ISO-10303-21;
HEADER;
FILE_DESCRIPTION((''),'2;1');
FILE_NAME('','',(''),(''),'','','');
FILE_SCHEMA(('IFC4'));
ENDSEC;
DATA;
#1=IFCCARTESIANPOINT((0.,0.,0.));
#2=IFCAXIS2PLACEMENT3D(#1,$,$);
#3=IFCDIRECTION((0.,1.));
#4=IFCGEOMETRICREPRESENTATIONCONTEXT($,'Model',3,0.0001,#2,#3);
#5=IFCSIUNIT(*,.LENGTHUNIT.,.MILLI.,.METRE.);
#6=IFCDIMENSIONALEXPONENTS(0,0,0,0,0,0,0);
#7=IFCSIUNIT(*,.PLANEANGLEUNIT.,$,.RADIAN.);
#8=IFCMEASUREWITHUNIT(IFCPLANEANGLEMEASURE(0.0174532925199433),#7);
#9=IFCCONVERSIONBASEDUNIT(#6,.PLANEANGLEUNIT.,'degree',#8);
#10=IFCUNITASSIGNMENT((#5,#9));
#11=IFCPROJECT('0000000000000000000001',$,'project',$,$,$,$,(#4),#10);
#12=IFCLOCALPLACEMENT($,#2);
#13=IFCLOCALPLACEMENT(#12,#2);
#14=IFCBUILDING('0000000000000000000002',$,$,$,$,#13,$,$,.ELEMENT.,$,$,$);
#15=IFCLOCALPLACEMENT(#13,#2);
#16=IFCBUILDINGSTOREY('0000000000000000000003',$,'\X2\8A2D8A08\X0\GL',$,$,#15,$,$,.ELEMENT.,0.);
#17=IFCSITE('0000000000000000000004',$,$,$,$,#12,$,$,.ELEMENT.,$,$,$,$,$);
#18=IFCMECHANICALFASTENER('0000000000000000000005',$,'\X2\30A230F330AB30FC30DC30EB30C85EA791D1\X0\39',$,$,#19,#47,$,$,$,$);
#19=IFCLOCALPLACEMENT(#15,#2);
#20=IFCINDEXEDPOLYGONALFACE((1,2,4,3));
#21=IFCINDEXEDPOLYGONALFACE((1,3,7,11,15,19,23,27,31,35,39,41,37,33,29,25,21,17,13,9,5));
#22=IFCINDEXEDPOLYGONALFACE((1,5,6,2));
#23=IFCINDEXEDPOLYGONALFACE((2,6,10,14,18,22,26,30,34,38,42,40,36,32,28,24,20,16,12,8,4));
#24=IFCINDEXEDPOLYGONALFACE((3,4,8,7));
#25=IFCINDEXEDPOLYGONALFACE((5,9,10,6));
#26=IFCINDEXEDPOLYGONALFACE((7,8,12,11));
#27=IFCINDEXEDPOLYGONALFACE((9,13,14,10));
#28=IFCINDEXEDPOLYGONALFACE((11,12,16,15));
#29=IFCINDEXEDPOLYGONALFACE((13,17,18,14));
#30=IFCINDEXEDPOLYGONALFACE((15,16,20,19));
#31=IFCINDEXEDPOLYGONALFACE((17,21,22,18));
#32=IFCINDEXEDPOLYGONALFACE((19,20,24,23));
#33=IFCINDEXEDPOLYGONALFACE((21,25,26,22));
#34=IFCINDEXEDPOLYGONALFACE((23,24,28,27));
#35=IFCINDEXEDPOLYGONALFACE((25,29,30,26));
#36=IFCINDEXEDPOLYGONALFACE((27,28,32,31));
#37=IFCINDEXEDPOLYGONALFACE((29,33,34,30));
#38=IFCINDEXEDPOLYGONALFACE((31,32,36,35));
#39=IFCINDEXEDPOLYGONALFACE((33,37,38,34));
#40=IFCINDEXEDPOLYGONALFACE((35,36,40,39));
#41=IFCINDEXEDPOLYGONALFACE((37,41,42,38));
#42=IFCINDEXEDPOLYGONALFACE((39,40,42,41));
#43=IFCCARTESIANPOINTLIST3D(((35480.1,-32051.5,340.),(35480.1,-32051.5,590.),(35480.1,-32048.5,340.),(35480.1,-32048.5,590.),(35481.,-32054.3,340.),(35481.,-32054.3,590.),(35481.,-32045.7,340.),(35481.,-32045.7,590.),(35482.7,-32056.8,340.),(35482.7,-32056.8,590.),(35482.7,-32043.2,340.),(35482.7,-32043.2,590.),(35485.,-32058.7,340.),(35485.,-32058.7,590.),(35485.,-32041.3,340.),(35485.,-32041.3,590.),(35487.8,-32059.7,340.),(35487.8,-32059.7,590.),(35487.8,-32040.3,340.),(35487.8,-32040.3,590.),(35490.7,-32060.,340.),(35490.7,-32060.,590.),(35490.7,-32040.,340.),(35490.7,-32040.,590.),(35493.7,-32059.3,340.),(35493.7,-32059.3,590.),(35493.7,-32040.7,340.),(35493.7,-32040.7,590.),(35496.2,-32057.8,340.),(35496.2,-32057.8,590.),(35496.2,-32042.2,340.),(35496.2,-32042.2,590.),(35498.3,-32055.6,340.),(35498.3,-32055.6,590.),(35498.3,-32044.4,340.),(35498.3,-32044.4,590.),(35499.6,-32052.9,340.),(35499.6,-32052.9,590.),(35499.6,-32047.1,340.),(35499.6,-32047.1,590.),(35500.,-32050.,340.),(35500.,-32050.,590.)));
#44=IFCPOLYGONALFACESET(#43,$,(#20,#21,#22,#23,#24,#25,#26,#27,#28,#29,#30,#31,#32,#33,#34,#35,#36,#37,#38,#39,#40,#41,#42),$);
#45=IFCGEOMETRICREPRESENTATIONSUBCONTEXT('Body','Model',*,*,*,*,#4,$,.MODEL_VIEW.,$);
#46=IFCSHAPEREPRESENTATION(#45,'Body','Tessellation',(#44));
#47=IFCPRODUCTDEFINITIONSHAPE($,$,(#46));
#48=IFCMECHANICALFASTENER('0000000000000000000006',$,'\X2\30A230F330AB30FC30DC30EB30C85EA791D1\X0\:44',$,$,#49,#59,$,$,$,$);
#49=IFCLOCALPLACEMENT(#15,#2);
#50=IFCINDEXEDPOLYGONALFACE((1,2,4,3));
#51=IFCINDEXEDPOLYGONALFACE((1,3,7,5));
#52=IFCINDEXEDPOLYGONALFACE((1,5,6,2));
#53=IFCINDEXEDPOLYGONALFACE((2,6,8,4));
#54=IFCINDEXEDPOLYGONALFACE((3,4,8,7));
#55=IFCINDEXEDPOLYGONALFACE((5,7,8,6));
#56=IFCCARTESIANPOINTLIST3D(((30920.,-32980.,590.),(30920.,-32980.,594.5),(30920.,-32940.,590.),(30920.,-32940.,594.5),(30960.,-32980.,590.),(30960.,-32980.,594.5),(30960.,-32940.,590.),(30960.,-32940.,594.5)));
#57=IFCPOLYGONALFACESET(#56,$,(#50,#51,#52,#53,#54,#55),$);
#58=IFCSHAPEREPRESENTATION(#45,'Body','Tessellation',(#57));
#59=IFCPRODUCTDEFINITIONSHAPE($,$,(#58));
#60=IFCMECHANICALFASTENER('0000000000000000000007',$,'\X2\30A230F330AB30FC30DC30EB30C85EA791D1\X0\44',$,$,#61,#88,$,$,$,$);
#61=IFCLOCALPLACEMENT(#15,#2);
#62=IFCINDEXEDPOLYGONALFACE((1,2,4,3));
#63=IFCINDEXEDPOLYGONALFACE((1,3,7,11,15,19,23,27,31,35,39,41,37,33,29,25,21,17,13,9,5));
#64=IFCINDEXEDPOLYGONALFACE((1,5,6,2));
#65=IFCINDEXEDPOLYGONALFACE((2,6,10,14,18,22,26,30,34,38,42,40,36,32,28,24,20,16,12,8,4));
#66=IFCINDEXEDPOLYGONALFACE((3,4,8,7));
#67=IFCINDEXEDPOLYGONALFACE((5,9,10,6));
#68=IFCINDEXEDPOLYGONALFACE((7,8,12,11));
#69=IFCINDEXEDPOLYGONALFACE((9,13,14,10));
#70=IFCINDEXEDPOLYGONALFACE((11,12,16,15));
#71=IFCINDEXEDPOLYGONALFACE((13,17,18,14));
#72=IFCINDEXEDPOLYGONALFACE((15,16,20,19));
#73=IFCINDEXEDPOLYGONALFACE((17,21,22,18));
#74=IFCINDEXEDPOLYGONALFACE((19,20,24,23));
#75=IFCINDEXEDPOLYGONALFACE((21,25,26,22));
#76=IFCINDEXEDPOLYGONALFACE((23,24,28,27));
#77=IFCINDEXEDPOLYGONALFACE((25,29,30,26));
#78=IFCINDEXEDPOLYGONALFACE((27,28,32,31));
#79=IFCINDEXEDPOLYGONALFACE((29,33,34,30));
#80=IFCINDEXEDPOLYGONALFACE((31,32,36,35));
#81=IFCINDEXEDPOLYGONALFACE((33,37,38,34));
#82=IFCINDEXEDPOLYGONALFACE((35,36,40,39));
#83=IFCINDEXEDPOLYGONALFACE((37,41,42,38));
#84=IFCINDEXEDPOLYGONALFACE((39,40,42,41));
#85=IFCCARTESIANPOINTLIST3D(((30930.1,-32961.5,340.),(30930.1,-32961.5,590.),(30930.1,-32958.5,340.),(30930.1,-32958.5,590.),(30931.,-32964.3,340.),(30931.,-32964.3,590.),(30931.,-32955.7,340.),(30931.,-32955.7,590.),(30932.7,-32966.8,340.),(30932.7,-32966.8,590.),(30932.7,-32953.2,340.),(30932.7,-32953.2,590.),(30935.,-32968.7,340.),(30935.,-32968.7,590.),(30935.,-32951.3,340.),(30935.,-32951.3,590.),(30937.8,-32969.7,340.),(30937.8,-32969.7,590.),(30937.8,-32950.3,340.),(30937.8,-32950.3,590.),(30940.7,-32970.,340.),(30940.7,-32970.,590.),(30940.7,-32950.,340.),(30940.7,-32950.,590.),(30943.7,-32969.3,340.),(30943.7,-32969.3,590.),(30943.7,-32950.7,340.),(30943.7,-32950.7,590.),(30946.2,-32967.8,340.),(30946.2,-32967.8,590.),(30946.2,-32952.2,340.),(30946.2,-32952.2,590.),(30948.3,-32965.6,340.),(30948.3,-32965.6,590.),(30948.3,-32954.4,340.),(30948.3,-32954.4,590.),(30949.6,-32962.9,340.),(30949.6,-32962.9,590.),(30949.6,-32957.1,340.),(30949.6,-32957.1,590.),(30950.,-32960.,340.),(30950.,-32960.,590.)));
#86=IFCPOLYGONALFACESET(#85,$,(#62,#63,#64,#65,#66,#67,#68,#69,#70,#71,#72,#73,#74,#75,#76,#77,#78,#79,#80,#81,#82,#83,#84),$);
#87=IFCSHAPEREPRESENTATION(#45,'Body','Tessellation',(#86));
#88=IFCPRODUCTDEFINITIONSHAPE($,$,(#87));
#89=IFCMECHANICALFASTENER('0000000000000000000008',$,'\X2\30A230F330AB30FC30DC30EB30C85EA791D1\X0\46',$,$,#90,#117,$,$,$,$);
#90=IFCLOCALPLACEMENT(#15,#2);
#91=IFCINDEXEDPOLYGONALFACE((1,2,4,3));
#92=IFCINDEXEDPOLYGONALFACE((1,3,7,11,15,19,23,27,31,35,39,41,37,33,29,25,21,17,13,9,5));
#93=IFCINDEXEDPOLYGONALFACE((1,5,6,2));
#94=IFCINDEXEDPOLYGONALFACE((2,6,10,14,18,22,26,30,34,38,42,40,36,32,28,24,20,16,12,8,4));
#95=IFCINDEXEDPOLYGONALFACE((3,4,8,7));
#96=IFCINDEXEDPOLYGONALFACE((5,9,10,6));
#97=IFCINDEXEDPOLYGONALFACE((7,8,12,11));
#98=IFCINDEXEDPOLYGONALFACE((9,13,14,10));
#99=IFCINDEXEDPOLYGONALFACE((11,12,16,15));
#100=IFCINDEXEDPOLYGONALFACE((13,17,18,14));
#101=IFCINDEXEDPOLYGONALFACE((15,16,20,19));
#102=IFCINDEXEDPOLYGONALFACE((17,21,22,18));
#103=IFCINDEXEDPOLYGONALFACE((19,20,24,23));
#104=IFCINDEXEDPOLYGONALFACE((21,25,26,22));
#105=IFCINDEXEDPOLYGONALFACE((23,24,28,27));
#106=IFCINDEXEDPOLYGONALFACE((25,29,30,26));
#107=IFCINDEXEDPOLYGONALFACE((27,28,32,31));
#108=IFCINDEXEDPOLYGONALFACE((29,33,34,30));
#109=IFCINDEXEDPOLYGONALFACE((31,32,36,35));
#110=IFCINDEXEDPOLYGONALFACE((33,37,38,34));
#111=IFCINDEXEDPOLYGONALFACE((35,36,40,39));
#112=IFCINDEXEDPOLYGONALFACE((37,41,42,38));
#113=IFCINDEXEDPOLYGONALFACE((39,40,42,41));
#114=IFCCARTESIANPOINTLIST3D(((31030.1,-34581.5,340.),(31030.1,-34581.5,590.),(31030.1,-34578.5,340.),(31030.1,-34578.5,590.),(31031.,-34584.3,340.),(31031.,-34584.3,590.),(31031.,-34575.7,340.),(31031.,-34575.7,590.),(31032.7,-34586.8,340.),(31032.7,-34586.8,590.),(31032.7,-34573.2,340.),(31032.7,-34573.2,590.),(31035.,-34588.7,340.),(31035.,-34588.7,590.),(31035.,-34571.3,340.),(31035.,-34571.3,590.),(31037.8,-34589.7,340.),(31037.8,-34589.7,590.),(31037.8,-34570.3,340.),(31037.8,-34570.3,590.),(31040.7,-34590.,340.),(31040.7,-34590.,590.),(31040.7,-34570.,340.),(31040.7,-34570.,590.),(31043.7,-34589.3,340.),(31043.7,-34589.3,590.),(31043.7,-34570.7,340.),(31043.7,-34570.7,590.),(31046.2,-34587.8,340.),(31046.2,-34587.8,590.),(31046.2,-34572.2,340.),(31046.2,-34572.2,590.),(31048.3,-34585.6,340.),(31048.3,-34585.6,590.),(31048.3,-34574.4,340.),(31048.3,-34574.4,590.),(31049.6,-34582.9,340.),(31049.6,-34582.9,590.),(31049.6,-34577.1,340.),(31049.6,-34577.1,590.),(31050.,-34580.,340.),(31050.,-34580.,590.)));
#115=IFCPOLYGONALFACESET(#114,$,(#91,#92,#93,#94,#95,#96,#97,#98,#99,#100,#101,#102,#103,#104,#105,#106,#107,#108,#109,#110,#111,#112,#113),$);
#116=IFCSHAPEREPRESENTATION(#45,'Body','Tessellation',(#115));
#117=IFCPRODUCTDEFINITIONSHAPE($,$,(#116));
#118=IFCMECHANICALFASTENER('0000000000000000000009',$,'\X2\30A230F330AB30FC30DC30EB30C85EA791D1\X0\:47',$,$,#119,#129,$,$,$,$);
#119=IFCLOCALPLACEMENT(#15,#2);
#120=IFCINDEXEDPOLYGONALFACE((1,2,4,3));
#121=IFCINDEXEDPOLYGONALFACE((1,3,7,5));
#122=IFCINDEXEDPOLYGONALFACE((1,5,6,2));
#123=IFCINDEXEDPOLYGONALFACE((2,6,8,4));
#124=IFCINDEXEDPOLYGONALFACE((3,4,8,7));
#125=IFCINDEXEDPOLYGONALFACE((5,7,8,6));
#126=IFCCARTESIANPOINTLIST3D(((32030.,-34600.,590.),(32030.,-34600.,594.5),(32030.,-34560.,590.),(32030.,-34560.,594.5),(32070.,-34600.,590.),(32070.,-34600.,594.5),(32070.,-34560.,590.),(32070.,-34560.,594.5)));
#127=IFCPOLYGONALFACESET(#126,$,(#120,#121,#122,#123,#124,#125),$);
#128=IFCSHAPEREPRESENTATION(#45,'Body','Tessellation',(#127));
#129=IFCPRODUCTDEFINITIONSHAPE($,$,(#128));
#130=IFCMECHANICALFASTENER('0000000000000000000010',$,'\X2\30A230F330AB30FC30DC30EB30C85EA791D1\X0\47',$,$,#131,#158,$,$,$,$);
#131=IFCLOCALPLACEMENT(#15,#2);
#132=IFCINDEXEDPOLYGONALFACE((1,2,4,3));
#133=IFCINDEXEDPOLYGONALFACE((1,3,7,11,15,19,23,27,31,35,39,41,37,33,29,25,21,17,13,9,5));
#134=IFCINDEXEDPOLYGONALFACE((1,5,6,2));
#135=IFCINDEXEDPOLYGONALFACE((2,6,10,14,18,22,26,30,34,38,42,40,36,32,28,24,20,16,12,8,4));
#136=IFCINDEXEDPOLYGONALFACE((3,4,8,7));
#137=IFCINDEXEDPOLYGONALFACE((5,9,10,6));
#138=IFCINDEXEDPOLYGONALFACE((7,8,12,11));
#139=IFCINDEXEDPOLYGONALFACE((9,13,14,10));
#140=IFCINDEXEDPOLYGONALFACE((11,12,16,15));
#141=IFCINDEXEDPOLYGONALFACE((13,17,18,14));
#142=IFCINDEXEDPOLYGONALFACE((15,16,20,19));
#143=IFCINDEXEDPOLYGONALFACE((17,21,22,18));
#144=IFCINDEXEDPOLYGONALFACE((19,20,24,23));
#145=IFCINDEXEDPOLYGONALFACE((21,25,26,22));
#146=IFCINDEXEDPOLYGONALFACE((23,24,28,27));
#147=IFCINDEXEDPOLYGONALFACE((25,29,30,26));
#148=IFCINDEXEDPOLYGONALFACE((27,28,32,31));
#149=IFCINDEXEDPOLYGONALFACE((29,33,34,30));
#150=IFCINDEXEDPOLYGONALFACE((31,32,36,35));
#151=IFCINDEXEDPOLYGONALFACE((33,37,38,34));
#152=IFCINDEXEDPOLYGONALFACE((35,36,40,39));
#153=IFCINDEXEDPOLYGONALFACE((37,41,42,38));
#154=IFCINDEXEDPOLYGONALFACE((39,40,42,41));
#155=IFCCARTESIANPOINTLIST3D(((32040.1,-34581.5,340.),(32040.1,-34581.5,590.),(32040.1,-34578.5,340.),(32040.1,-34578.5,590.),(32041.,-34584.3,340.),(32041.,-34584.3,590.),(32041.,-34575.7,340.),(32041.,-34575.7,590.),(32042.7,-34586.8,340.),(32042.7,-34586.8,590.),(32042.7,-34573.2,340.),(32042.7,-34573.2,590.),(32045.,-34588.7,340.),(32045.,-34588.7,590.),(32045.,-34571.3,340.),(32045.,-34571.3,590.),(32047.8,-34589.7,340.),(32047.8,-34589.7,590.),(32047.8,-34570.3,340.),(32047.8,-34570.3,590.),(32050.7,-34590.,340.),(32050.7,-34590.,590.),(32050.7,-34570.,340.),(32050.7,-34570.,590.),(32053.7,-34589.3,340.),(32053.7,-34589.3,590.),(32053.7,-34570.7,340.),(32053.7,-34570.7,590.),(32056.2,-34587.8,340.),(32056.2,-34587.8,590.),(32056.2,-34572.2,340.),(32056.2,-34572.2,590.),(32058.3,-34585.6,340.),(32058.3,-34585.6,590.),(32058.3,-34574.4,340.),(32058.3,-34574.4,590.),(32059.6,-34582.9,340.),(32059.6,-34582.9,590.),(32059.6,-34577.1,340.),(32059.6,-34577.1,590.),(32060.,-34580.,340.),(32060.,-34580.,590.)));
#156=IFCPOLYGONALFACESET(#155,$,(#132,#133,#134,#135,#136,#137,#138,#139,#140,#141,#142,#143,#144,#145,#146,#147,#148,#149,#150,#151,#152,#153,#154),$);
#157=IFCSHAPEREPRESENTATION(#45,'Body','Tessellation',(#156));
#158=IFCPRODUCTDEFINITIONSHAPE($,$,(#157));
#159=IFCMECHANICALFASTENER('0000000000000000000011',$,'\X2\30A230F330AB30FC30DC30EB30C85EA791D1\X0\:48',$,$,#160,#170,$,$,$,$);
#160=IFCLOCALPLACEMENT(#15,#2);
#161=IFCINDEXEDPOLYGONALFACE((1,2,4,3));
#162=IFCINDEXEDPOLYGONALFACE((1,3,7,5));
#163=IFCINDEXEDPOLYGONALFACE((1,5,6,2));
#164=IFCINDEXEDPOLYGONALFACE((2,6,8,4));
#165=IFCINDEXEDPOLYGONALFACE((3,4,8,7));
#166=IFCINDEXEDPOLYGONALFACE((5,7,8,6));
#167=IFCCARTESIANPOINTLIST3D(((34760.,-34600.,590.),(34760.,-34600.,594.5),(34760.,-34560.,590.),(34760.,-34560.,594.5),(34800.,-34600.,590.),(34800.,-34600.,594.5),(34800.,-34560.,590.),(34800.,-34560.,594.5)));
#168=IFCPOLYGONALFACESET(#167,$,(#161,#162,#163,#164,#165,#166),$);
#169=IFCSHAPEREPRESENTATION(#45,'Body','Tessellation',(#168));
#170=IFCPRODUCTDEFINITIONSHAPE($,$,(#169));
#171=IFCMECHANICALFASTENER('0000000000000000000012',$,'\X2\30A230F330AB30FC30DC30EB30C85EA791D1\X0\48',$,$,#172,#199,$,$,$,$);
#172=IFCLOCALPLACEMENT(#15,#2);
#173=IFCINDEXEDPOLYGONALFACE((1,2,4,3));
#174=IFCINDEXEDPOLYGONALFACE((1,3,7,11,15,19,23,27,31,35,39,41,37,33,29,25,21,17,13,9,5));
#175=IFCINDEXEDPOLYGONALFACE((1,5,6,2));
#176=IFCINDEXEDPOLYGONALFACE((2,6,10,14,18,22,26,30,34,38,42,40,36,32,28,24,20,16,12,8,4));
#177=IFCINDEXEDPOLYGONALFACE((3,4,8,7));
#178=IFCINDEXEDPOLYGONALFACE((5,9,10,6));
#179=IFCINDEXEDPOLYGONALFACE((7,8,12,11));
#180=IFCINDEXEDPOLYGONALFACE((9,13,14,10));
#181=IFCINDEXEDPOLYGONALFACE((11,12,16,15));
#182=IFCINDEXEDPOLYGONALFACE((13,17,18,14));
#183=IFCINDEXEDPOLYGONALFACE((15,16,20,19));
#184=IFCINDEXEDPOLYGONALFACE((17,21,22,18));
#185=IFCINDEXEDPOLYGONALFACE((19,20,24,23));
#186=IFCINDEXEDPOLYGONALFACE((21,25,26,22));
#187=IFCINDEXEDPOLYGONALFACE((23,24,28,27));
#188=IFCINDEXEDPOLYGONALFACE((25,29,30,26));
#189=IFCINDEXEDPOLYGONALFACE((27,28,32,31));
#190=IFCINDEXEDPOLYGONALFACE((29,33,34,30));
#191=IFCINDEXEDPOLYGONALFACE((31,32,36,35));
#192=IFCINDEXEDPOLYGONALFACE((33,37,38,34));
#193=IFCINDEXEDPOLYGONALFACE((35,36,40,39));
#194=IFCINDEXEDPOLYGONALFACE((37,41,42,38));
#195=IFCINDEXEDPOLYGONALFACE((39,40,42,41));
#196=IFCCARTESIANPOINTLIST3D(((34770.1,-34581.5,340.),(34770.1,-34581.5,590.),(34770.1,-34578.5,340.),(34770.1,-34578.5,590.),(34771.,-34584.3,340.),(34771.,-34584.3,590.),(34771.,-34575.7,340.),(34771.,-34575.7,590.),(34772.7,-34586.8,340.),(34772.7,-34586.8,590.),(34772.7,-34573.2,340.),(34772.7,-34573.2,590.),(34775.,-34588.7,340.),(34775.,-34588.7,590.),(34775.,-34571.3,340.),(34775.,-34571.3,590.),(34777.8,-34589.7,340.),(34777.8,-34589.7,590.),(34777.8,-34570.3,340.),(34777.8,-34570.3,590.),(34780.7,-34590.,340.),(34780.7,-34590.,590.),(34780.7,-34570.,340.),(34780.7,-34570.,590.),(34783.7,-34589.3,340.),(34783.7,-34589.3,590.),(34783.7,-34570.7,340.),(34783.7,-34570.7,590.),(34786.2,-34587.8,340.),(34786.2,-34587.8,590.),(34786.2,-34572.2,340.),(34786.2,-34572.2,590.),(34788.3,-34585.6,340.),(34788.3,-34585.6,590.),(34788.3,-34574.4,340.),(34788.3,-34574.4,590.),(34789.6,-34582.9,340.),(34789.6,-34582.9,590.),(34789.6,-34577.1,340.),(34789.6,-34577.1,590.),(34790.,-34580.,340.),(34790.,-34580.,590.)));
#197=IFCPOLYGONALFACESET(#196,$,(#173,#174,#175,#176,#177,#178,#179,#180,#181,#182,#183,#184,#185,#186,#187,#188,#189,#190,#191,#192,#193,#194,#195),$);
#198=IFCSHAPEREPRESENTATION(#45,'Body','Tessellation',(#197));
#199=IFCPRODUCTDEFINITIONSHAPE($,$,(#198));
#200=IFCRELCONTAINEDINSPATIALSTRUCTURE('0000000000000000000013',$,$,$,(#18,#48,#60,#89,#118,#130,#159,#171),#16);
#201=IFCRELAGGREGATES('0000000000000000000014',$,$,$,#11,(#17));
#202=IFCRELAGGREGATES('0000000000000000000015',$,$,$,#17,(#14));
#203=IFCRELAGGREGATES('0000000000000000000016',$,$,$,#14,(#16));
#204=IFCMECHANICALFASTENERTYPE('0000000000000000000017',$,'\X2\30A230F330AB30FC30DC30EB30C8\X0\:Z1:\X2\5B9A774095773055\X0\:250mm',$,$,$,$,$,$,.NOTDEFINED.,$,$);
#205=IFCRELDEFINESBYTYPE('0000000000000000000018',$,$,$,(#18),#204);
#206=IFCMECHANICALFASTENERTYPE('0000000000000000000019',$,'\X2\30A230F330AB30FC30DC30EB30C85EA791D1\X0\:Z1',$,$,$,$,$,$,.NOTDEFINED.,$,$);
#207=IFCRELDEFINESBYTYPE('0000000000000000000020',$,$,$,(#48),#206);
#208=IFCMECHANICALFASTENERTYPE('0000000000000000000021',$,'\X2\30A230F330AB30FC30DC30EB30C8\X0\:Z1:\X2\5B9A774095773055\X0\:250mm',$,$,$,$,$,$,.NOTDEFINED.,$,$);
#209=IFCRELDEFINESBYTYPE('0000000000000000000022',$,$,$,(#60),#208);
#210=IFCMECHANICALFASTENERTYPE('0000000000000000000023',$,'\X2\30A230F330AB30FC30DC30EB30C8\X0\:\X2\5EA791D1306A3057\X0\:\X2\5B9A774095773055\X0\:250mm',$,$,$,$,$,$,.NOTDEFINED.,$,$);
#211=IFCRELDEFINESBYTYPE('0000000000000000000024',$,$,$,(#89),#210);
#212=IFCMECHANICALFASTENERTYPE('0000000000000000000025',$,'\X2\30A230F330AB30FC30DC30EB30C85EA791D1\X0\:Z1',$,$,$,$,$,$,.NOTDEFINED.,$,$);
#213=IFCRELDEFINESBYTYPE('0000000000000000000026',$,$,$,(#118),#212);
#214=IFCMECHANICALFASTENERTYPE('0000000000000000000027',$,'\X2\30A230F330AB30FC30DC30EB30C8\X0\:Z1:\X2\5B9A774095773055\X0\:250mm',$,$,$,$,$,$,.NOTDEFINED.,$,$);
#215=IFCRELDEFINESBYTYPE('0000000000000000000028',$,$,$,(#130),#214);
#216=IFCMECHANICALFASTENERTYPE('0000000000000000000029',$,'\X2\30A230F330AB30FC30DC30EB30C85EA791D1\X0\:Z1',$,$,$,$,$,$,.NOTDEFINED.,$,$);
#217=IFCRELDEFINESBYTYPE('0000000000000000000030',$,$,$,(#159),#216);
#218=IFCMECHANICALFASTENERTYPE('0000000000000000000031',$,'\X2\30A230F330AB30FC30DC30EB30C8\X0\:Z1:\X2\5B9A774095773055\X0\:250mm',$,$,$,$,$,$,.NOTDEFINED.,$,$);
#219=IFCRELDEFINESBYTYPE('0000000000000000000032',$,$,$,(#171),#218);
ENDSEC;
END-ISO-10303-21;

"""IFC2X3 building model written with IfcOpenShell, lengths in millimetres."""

from ifc_helpers import new_model, entity, si_unit, converted_unit, direction, frame, origin, origin_with_axes, origin_2d, place, context, subcontext, project, spatial, rectangle, circle, extrude, type_object, element, save


model = new_model("IFC2X3")

# Units and contexts
model_context = context("Model", 3, precision=0.0001, world=origin(), true_north=direction((0.0, 1.0)))
body_context = subcontext(model_context, "Body", "Model", "MODEL_VIEW")
ifc_project = project(units=[si_unit("LENGTHUNIT", "METRE", prefix="MILLI"), converted_unit("PLANEANGLEUNIT", "degree", entity("IfcPlaneAngleMeasure", 0.0174532925199433), si_unit("PLANEANGLEUNIT", "RADIAN"), dimensions=[0, 0, 0, 0, 0, 0, 0])], contexts=[model_context])

# Site, building, storey
site_placement = place(None, origin())
site = spatial("IfcSite", under=ifc_project, at=site_placement, CompositionType="ELEMENT")
building_placement = place(site_placement, origin())
building = spatial("IfcBuilding", under=site, at=building_placement, CompositionType="ELEMENT")
storey_placement = place(building_placement, origin())
storey = spatial("IfcBuildingStorey", under=building, at=storey_placement, Name="設計GL", CompositionType="ELEMENT", Elevation=0.0)

# Mechanical fasteners
mechanical_fastener_type_1 = type_object("IfcMechanicalFastenerType", Name="アンカーボルト:Z1:定着長さ:250mm")
mechanical_fastener_1_placement = place(storey_placement, frame((35490.0, -32050.0, 340.0)))
element("IfcMechanicalFastener", 1, at=mechanical_fastener_1_placement, inside=storey, type_object=mechanical_fastener_type_1, Name="アンカーボルト座金39", context=body_context, shape_type="SweptSolid", body=[
    extrude(circle(Radius=10.0, at=origin_2d()), origin_with_axes(), (0.0, 0.0, 1.0), 250.0),
])
mechanical_fastener_type_2 = type_object("IfcMechanicalFastenerType", Name="アンカーボルト座金:Z1")
mechanical_fastener_2_placement = place(storey_placement, frame((30940.0, -32960.0, 590.0)))
element("IfcMechanicalFastener", 2, at=mechanical_fastener_2_placement, inside=storey, type_object=mechanical_fastener_type_2, Name="アンカーボルト座金:44", context=body_context, shape_type="SweptSolid", body=[
    extrude(rectangle(XDim=40.0, YDim=40.0, at=origin_2d()), origin_with_axes(), (0.0, 0.0, 1.0), 4.5),
])
mechanical_fastener_type_3 = type_object("IfcMechanicalFastenerType", Name="アンカーボルト:Z1:定着長さ:250mm")
mechanical_fastener_3_placement = place(storey_placement, frame((30940.0, -32960.0, 340.0)))
element("IfcMechanicalFastener", 3, at=mechanical_fastener_3_placement, inside=storey, type_object=mechanical_fastener_type_3, Name="アンカーボルト座金44", context=body_context, shape_type="SweptSolid", body=[
    extrude(circle(Radius=10.0, at=origin_2d()), origin_with_axes(), (0.0, 0.0, 1.0), 250.0),
])
mechanical_fastener_type_4 = type_object("IfcMechanicalFastenerType", Name="アンカーボルト:座金なし:定着長さ:250mm")
mechanical_fastener_4_placement = place(storey_placement, frame((31040.0, -34580.0, 340.0)))
element("IfcMechanicalFastener", 4, at=mechanical_fastener_4_placement, inside=storey, type_object=mechanical_fastener_type_4, Name="アンカーボルト座金46", context=body_context, shape_type="SweptSolid", body=[
    extrude(circle(Radius=10.0, at=origin_2d()), origin_with_axes(), (0.0, 0.0, 1.0), 250.0),
])
mechanical_fastener_type_5 = type_object("IfcMechanicalFastenerType", Name="アンカーボルト座金:Z1")
mechanical_fastener_5_placement = place(storey_placement, frame((32050.0, -34580.0, 590.0)))
element("IfcMechanicalFastener", 5, at=mechanical_fastener_5_placement, inside=storey, type_object=mechanical_fastener_type_5, Name="アンカーボルト座金:47", context=body_context, shape_type="SweptSolid", body=[
    extrude(rectangle(XDim=40.0, YDim=40.0, at=origin_2d()), origin_with_axes(), (0.0, 0.0, 1.0), 4.5),
])
mechanical_fastener_type_6 = type_object("IfcMechanicalFastenerType", Name="アンカーボルト:Z1:定着長さ:250mm")
mechanical_fastener_6_placement = place(storey_placement, frame((32050.0, -34580.0, 340.0)))
element("IfcMechanicalFastener", 6, at=mechanical_fastener_6_placement, inside=storey, type_object=mechanical_fastener_type_6, Name="アンカーボルト座金47", context=body_context, shape_type="SweptSolid", body=[
    extrude(circle(Radius=10.0, at=origin_2d()), origin_with_axes(), (0.0, 0.0, 1.0), 250.0),
])
mechanical_fastener_type_7 = type_object("IfcMechanicalFastenerType", Name="アンカーボルト座金:Z1")
mechanical_fastener_7_placement = place(storey_placement, frame((34780.0, -34580.0, 590.0)))
element("IfcMechanicalFastener", 7, at=mechanical_fastener_7_placement, inside=storey, type_object=mechanical_fastener_type_7, Name="アンカーボルト座金:48", context=body_context, shape_type="SweptSolid", body=[
    extrude(rectangle(XDim=40.0, YDim=40.0, at=origin_2d()), origin_with_axes(), (0.0, 0.0, 1.0), 4.5),
])
mechanical_fastener_type_8 = type_object("IfcMechanicalFastenerType", Name="アンカーボルト:Z1:定着長さ:250mm")
mechanical_fastener_8_placement = place(storey_placement, frame((34780.0, -34580.0, 340.0)))
element("IfcMechanicalFastener", 8, at=mechanical_fastener_8_placement, inside=storey, type_object=mechanical_fastener_type_8, Name="アンカーボルト座金48", context=body_context, shape_type="SweptSolid", body=[
    extrude(circle(Radius=10.0, at=origin_2d()), origin_with_axes(), (0.0, 0.0, 1.0), 250.0),
])

save(model, "model.ifc")
